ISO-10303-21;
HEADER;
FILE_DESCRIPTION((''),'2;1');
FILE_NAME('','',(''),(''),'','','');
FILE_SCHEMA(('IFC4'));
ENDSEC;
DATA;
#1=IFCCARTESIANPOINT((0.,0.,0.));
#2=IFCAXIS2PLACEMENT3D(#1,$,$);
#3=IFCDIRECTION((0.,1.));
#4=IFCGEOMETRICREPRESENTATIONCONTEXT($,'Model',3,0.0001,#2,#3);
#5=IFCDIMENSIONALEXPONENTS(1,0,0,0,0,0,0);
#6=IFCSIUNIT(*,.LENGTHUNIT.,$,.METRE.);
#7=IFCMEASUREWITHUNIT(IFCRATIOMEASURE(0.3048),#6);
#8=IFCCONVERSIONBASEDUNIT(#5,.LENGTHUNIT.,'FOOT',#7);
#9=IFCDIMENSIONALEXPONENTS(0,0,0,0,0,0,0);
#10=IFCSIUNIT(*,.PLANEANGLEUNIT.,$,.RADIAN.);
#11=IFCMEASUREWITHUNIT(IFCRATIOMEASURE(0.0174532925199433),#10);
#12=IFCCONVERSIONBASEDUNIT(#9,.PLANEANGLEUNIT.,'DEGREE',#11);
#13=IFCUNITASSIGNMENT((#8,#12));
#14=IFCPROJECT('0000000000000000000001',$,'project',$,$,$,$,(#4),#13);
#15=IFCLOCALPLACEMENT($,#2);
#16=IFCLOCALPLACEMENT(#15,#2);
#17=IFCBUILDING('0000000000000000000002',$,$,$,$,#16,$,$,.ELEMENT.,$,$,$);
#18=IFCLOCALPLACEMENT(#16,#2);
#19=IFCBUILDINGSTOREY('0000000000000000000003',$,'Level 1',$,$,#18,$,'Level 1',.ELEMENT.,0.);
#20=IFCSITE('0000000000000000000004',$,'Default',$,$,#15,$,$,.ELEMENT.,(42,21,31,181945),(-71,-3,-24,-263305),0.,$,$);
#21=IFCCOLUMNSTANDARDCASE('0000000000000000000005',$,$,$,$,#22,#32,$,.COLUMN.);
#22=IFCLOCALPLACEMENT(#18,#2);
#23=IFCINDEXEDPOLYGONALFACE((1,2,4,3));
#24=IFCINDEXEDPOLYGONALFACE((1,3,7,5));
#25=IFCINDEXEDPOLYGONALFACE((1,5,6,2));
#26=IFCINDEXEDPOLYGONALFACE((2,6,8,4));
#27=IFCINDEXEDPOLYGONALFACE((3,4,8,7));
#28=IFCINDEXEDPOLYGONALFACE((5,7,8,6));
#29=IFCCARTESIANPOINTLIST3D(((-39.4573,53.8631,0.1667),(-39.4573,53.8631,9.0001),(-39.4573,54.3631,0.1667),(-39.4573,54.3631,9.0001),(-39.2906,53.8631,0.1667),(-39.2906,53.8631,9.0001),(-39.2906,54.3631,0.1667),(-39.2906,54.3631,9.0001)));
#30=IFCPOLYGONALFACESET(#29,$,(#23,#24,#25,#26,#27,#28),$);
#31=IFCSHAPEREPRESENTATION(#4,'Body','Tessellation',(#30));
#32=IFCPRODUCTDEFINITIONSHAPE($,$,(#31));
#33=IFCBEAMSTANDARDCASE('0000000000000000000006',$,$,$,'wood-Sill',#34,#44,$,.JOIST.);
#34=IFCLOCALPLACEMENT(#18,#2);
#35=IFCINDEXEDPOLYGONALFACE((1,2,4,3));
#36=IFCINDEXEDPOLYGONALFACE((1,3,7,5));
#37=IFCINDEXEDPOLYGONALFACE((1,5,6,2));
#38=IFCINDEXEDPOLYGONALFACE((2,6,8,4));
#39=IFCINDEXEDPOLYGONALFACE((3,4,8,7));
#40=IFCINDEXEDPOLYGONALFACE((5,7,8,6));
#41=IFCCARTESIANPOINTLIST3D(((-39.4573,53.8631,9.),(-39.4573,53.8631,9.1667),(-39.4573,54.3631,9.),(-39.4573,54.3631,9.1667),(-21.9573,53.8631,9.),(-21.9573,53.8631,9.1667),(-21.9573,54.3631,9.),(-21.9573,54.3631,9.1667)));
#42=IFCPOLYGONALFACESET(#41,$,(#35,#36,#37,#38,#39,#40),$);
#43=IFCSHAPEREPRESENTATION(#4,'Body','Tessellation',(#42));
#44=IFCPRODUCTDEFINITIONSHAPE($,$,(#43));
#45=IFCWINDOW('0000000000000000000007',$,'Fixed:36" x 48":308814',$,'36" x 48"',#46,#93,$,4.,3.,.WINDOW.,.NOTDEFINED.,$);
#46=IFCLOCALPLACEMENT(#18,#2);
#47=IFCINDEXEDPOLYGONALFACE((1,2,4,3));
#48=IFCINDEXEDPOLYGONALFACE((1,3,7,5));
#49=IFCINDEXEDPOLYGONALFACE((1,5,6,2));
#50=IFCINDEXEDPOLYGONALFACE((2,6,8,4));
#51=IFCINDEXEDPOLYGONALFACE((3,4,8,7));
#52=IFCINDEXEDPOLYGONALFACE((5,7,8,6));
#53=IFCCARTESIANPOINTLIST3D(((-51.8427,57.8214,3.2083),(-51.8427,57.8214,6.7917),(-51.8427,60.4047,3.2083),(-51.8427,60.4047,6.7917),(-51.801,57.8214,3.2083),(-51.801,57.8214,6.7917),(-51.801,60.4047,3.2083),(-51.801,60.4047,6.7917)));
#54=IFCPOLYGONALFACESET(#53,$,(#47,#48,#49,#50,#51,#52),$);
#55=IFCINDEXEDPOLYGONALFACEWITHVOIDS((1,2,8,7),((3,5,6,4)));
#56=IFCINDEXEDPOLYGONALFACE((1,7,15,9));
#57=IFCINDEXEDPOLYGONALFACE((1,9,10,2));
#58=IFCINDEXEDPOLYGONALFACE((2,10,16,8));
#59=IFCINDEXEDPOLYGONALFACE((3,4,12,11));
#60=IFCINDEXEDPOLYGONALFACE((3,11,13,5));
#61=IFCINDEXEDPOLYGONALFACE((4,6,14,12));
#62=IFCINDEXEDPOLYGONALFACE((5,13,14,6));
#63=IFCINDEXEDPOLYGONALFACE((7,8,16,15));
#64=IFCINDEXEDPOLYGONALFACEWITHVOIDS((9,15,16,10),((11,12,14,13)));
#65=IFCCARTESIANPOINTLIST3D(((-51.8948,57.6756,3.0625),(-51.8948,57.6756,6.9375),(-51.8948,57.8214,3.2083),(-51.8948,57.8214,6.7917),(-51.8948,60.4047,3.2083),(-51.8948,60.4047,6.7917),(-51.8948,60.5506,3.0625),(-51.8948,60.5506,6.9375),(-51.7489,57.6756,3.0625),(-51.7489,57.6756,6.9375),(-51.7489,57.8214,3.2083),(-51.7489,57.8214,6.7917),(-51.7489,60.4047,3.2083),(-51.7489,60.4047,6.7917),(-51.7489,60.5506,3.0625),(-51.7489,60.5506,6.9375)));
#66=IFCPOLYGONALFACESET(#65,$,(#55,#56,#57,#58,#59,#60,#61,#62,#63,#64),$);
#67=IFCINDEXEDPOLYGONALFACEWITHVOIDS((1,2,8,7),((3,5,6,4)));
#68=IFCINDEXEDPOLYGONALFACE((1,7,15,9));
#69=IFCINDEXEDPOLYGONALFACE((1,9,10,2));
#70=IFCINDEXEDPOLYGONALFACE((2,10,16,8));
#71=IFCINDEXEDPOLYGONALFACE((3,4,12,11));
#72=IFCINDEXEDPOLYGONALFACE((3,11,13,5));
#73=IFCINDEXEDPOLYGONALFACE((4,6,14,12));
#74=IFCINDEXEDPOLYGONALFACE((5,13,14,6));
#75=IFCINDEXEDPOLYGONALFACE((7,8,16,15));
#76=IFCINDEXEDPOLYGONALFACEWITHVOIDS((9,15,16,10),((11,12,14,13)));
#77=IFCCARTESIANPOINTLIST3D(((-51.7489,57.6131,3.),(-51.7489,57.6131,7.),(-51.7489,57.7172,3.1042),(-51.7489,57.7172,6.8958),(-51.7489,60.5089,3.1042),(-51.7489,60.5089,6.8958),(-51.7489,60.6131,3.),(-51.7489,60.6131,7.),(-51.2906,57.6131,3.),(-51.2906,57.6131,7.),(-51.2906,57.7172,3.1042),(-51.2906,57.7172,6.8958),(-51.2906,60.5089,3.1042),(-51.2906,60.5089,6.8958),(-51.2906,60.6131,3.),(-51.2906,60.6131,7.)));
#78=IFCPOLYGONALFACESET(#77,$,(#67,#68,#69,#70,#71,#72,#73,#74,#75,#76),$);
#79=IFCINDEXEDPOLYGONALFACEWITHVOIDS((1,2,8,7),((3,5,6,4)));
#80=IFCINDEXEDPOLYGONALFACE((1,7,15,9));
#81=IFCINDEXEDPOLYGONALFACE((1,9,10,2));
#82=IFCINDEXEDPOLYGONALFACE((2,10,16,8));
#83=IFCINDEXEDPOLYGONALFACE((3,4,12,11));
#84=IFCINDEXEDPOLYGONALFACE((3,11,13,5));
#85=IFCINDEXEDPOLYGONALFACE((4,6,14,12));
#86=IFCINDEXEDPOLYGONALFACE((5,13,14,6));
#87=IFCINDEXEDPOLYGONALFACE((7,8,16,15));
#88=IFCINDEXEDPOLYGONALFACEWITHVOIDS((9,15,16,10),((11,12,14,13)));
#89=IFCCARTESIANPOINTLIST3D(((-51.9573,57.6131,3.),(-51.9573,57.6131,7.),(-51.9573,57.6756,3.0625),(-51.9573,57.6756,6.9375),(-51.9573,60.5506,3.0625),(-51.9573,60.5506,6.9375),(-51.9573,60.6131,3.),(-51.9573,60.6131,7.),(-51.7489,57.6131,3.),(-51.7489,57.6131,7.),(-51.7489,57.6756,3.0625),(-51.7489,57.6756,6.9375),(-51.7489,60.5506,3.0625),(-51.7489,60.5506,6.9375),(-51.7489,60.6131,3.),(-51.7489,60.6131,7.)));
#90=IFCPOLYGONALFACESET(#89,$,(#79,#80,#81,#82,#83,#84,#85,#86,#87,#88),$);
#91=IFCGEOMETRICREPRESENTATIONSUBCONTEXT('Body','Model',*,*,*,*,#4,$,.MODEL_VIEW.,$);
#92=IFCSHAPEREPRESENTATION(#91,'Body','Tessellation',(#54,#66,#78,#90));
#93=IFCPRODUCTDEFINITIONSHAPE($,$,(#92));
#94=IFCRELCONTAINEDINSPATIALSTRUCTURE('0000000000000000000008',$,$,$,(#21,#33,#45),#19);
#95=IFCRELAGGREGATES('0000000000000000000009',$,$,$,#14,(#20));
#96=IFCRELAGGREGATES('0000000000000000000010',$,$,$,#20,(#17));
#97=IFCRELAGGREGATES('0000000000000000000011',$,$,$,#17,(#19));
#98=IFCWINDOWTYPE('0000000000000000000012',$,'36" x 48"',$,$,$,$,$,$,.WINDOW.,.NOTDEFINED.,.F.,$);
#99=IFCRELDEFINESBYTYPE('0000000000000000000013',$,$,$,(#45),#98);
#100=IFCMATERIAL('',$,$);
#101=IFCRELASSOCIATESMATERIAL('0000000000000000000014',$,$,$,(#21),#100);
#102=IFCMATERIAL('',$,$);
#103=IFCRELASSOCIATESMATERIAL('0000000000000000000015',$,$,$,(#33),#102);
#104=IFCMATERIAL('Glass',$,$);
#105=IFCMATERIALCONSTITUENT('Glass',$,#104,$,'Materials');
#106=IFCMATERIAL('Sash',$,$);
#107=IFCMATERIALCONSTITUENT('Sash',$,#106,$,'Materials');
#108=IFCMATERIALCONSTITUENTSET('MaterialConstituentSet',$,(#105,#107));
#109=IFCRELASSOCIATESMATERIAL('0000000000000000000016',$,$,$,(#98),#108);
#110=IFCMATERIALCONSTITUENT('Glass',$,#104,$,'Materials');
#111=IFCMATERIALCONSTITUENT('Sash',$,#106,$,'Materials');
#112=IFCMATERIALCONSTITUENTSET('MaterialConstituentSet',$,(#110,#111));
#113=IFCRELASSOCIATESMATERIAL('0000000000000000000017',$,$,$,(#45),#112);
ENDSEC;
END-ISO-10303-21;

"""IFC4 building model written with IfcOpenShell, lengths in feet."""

from ifc_helpers import new_model, entity, si_unit, converted_unit, direction, frame, frame_2d, origin, origin_with_axes, place, context, subcontext, project, spatial, polyline, rectangle, outline, extrude, source, transform, mapped, material, constituent, constituent_set, type_object, type_shapes, element, save


model = new_model("IFC4")

# Units and contexts
model_context = context("Model", 3, precision=0.0001, world=origin(), true_north=direction((0.0, 1.0)))
body_context = subcontext(model_context, "Body", "Model", "MODEL_VIEW")
ifc_project = project(units=[converted_unit("LENGTHUNIT", "FOOT", entity("IfcRatioMeasure", 0.3048), si_unit("LENGTHUNIT", "METRE"), dimensions=[1, 0, 0, 0, 0, 0, 0]), converted_unit("PLANEANGLEUNIT", "DEGREE", entity("IfcRatioMeasure", 0.0174532925199433), si_unit("PLANEANGLEUNIT", "RADIAN"), dimensions=[0, 0, 0, 0, 0, 0, 0])], contexts=[model_context])

# Site, building, storey
site_placement = place(None, origin())
site = spatial("IfcSite", under=ifc_project, at=site_placement, Name="Default", CompositionType="ELEMENT", RefLatitude=(42, 21, 31, 181945), RefLongitude=(-71, -3, -24, -263305), RefElevation=0.0)
building_placement = place(site_placement, origin())
building = spatial("IfcBuilding", under=site, at=building_placement, CompositionType="ELEMENT")
storey_placement = place(building_placement, origin())
storey = spatial("IfcBuildingStorey", under=building, at=storey_placement, Name="Level 1", LongName="Level 1", CompositionType="ELEMENT", Elevation=0.0)

# Column
placement_1 = place(storey_placement, frame((-51.6239, 66.9464, 0.0), z_axis=(0.0, 0.0, 1.0), x_axis=(0.0, -1.0, 0.0)))
ifc_material_1 = material(Name="")
placement_2 = place(storey_placement, frame((-39.4573, 54.1131, 0.0)))
column_placement = place(placement_2, frame((0.0833, 0.0, 0.1667), z_axis=(0.0, 0.0, 1.0), x_axis=(1.0, 0.0, 0.0)))
element("IfcColumnStandardCase", 1, at=column_placement, inside=storey, material=ifc_material_1, PredefinedType="COLUMN", context=model_context, shape_type="SweptSolid", body=[
    extrude(rectangle(XDim=0.1667, YDim=0.5), origin(), (0.0, 0.0, 1.0), 8.8334),
])

# Beam
ifc_material_2 = material(Name="")
beam_1_placement = place(placement_2, frame((0.0, 0.0, 9.0834), z_axis=(1.0, 0.0, 0.0), x_axis=(0.0, 0.0, 1.0)))
element("IfcBeamStandardCase", 2, at=beam_1_placement, inside=storey, material=ifc_material_2, ObjectType="wood-Sill", PredefinedType="JOIST", context=model_context, shape_type="SweptSolid", body=[
    extrude(rectangle(XDim=0.1667, YDim=0.5), origin_with_axes(), (0.0, 0.0, 1.0), 17.5),
])

# Window
ifc_material_3 = material(Name="Glass")
ifc_constituent_1 = constituent(ifc_material_3, Name="Glass", Category="Materials")
ifc_material_4 = material(Name="Sash")
ifc_constituent_2 = constituent(ifc_material_4, Name="Sash", Category="Materials")
ifc_constituent_set_1 = constituent_set(constituents=[ifc_constituent_1, ifc_constituent_2], Name="MaterialConstituentSet")
ifc_constituent_3 = constituent(ifc_material_3, Name="Glass", Category="Materials")
ifc_constituent_4 = constituent(ifc_material_4, Name="Sash", Category="Materials")
ifc_constituent_set_2 = constituent_set(constituents=[ifc_constituent_3, ifc_constituent_4], Name="MaterialConstituentSet")
window_type = type_object("IfcWindowType", Name="36\" x 48\"", ParameterTakesPrecedence=False, PartitioningType="NOTDEFINED", PredefinedType="WINDOW", material=ifc_constituent_set_2)
shared_shape = source(origin(), body_context, "Body", "SweptSolid", [
    extrude(rectangle(XDim=0.0417, YDim=2.5833, at=frame_2d((0.0, 0.0), x_axis=(1.0, 0.0))), frame((1.5, 0.5312, 0.2083), z_axis=(0.0, 0.0, 1.0), x_axis=(0.0, 1.0, 0.0)), (0.0, 0.0, 1.0), 3.5833),
    extrude(outline(polyline([(-1.4375, -1.9375), (1.4375, -1.9375), (1.4375, 1.9375), (-1.4375, 1.9375), (-1.4375, -1.9375)]), holes=[polyline([(-1.2917, -1.7917), (-1.2917, 1.7917), (1.2917, 1.7917), (1.2917, -1.7917), (-1.2917, -1.7917)])]), frame((1.5, 0.4583, 2.0), z_axis=(0.0, 1.0, 0.0), x_axis=(1.0, 0.0, 0.0)), (0.0, 0.0, 1.0), 0.1458),
    extrude(outline(polyline([(-1.5, -2.0), (1.5, -2.0), (1.5, 2.0), (-1.5, 2.0), (-1.5, -2.0)]), holes=[polyline([(-1.3958, -1.8958), (-1.3958, 1.8958), (1.3958, 1.8958), (1.3958, -1.8958), (-1.3958, -1.8958)])]), frame((1.5, 0.0, 2.0), z_axis=(0.0, 1.0, 0.0), x_axis=(1.0, 0.0, 0.0)), (0.0, 0.0, 1.0), 0.4583),
    extrude(outline(polyline([(-2.0, -1.5), (2.0, -1.5), (2.0, 1.5), (-2.0, 1.5), (-2.0, -1.5)]), holes=[polyline([(-1.9375, -1.4375), (-1.9375, 1.4375), (1.9375, 1.4375), (1.9375, -1.4375), (-1.9375, -1.4375)])]), frame((1.5, 0.4583, 2.0), z_axis=(0.0, 1.0, 0.0), x_axis=(0.0, 0.0, -1.0)), (0.0, 0.0, 1.0), 0.2083),
])
type_shapes(window_type, [shared_shape])
placement_3 = place(placement_1, frame((9.3333, 0.3333, 3.0)))
window_placement = place(placement_3, frame((0.0, 0.0, 0.0), z_axis=(0.0, 0.0, 1.0), x_axis=(-1.0, 0.0, 0.0)))
element("IfcWindow", 3, at=window_placement, inside=storey, type_object=window_type, material=ifc_constituent_set_1, Name="Fixed:36\" x 48\":308814", ObjectType="36\" x 48\"", OverallHeight=4.0, OverallWidth=3.0, PartitioningType="NOTDEFINED", PredefinedType="WINDOW", context=body_context, shape_type="MappedRepresentation", body=[
    mapped(shared_shape, transform((0.0, 0.0, 0.0), scale=1.0)),
])

save(model, "model.ifc")
